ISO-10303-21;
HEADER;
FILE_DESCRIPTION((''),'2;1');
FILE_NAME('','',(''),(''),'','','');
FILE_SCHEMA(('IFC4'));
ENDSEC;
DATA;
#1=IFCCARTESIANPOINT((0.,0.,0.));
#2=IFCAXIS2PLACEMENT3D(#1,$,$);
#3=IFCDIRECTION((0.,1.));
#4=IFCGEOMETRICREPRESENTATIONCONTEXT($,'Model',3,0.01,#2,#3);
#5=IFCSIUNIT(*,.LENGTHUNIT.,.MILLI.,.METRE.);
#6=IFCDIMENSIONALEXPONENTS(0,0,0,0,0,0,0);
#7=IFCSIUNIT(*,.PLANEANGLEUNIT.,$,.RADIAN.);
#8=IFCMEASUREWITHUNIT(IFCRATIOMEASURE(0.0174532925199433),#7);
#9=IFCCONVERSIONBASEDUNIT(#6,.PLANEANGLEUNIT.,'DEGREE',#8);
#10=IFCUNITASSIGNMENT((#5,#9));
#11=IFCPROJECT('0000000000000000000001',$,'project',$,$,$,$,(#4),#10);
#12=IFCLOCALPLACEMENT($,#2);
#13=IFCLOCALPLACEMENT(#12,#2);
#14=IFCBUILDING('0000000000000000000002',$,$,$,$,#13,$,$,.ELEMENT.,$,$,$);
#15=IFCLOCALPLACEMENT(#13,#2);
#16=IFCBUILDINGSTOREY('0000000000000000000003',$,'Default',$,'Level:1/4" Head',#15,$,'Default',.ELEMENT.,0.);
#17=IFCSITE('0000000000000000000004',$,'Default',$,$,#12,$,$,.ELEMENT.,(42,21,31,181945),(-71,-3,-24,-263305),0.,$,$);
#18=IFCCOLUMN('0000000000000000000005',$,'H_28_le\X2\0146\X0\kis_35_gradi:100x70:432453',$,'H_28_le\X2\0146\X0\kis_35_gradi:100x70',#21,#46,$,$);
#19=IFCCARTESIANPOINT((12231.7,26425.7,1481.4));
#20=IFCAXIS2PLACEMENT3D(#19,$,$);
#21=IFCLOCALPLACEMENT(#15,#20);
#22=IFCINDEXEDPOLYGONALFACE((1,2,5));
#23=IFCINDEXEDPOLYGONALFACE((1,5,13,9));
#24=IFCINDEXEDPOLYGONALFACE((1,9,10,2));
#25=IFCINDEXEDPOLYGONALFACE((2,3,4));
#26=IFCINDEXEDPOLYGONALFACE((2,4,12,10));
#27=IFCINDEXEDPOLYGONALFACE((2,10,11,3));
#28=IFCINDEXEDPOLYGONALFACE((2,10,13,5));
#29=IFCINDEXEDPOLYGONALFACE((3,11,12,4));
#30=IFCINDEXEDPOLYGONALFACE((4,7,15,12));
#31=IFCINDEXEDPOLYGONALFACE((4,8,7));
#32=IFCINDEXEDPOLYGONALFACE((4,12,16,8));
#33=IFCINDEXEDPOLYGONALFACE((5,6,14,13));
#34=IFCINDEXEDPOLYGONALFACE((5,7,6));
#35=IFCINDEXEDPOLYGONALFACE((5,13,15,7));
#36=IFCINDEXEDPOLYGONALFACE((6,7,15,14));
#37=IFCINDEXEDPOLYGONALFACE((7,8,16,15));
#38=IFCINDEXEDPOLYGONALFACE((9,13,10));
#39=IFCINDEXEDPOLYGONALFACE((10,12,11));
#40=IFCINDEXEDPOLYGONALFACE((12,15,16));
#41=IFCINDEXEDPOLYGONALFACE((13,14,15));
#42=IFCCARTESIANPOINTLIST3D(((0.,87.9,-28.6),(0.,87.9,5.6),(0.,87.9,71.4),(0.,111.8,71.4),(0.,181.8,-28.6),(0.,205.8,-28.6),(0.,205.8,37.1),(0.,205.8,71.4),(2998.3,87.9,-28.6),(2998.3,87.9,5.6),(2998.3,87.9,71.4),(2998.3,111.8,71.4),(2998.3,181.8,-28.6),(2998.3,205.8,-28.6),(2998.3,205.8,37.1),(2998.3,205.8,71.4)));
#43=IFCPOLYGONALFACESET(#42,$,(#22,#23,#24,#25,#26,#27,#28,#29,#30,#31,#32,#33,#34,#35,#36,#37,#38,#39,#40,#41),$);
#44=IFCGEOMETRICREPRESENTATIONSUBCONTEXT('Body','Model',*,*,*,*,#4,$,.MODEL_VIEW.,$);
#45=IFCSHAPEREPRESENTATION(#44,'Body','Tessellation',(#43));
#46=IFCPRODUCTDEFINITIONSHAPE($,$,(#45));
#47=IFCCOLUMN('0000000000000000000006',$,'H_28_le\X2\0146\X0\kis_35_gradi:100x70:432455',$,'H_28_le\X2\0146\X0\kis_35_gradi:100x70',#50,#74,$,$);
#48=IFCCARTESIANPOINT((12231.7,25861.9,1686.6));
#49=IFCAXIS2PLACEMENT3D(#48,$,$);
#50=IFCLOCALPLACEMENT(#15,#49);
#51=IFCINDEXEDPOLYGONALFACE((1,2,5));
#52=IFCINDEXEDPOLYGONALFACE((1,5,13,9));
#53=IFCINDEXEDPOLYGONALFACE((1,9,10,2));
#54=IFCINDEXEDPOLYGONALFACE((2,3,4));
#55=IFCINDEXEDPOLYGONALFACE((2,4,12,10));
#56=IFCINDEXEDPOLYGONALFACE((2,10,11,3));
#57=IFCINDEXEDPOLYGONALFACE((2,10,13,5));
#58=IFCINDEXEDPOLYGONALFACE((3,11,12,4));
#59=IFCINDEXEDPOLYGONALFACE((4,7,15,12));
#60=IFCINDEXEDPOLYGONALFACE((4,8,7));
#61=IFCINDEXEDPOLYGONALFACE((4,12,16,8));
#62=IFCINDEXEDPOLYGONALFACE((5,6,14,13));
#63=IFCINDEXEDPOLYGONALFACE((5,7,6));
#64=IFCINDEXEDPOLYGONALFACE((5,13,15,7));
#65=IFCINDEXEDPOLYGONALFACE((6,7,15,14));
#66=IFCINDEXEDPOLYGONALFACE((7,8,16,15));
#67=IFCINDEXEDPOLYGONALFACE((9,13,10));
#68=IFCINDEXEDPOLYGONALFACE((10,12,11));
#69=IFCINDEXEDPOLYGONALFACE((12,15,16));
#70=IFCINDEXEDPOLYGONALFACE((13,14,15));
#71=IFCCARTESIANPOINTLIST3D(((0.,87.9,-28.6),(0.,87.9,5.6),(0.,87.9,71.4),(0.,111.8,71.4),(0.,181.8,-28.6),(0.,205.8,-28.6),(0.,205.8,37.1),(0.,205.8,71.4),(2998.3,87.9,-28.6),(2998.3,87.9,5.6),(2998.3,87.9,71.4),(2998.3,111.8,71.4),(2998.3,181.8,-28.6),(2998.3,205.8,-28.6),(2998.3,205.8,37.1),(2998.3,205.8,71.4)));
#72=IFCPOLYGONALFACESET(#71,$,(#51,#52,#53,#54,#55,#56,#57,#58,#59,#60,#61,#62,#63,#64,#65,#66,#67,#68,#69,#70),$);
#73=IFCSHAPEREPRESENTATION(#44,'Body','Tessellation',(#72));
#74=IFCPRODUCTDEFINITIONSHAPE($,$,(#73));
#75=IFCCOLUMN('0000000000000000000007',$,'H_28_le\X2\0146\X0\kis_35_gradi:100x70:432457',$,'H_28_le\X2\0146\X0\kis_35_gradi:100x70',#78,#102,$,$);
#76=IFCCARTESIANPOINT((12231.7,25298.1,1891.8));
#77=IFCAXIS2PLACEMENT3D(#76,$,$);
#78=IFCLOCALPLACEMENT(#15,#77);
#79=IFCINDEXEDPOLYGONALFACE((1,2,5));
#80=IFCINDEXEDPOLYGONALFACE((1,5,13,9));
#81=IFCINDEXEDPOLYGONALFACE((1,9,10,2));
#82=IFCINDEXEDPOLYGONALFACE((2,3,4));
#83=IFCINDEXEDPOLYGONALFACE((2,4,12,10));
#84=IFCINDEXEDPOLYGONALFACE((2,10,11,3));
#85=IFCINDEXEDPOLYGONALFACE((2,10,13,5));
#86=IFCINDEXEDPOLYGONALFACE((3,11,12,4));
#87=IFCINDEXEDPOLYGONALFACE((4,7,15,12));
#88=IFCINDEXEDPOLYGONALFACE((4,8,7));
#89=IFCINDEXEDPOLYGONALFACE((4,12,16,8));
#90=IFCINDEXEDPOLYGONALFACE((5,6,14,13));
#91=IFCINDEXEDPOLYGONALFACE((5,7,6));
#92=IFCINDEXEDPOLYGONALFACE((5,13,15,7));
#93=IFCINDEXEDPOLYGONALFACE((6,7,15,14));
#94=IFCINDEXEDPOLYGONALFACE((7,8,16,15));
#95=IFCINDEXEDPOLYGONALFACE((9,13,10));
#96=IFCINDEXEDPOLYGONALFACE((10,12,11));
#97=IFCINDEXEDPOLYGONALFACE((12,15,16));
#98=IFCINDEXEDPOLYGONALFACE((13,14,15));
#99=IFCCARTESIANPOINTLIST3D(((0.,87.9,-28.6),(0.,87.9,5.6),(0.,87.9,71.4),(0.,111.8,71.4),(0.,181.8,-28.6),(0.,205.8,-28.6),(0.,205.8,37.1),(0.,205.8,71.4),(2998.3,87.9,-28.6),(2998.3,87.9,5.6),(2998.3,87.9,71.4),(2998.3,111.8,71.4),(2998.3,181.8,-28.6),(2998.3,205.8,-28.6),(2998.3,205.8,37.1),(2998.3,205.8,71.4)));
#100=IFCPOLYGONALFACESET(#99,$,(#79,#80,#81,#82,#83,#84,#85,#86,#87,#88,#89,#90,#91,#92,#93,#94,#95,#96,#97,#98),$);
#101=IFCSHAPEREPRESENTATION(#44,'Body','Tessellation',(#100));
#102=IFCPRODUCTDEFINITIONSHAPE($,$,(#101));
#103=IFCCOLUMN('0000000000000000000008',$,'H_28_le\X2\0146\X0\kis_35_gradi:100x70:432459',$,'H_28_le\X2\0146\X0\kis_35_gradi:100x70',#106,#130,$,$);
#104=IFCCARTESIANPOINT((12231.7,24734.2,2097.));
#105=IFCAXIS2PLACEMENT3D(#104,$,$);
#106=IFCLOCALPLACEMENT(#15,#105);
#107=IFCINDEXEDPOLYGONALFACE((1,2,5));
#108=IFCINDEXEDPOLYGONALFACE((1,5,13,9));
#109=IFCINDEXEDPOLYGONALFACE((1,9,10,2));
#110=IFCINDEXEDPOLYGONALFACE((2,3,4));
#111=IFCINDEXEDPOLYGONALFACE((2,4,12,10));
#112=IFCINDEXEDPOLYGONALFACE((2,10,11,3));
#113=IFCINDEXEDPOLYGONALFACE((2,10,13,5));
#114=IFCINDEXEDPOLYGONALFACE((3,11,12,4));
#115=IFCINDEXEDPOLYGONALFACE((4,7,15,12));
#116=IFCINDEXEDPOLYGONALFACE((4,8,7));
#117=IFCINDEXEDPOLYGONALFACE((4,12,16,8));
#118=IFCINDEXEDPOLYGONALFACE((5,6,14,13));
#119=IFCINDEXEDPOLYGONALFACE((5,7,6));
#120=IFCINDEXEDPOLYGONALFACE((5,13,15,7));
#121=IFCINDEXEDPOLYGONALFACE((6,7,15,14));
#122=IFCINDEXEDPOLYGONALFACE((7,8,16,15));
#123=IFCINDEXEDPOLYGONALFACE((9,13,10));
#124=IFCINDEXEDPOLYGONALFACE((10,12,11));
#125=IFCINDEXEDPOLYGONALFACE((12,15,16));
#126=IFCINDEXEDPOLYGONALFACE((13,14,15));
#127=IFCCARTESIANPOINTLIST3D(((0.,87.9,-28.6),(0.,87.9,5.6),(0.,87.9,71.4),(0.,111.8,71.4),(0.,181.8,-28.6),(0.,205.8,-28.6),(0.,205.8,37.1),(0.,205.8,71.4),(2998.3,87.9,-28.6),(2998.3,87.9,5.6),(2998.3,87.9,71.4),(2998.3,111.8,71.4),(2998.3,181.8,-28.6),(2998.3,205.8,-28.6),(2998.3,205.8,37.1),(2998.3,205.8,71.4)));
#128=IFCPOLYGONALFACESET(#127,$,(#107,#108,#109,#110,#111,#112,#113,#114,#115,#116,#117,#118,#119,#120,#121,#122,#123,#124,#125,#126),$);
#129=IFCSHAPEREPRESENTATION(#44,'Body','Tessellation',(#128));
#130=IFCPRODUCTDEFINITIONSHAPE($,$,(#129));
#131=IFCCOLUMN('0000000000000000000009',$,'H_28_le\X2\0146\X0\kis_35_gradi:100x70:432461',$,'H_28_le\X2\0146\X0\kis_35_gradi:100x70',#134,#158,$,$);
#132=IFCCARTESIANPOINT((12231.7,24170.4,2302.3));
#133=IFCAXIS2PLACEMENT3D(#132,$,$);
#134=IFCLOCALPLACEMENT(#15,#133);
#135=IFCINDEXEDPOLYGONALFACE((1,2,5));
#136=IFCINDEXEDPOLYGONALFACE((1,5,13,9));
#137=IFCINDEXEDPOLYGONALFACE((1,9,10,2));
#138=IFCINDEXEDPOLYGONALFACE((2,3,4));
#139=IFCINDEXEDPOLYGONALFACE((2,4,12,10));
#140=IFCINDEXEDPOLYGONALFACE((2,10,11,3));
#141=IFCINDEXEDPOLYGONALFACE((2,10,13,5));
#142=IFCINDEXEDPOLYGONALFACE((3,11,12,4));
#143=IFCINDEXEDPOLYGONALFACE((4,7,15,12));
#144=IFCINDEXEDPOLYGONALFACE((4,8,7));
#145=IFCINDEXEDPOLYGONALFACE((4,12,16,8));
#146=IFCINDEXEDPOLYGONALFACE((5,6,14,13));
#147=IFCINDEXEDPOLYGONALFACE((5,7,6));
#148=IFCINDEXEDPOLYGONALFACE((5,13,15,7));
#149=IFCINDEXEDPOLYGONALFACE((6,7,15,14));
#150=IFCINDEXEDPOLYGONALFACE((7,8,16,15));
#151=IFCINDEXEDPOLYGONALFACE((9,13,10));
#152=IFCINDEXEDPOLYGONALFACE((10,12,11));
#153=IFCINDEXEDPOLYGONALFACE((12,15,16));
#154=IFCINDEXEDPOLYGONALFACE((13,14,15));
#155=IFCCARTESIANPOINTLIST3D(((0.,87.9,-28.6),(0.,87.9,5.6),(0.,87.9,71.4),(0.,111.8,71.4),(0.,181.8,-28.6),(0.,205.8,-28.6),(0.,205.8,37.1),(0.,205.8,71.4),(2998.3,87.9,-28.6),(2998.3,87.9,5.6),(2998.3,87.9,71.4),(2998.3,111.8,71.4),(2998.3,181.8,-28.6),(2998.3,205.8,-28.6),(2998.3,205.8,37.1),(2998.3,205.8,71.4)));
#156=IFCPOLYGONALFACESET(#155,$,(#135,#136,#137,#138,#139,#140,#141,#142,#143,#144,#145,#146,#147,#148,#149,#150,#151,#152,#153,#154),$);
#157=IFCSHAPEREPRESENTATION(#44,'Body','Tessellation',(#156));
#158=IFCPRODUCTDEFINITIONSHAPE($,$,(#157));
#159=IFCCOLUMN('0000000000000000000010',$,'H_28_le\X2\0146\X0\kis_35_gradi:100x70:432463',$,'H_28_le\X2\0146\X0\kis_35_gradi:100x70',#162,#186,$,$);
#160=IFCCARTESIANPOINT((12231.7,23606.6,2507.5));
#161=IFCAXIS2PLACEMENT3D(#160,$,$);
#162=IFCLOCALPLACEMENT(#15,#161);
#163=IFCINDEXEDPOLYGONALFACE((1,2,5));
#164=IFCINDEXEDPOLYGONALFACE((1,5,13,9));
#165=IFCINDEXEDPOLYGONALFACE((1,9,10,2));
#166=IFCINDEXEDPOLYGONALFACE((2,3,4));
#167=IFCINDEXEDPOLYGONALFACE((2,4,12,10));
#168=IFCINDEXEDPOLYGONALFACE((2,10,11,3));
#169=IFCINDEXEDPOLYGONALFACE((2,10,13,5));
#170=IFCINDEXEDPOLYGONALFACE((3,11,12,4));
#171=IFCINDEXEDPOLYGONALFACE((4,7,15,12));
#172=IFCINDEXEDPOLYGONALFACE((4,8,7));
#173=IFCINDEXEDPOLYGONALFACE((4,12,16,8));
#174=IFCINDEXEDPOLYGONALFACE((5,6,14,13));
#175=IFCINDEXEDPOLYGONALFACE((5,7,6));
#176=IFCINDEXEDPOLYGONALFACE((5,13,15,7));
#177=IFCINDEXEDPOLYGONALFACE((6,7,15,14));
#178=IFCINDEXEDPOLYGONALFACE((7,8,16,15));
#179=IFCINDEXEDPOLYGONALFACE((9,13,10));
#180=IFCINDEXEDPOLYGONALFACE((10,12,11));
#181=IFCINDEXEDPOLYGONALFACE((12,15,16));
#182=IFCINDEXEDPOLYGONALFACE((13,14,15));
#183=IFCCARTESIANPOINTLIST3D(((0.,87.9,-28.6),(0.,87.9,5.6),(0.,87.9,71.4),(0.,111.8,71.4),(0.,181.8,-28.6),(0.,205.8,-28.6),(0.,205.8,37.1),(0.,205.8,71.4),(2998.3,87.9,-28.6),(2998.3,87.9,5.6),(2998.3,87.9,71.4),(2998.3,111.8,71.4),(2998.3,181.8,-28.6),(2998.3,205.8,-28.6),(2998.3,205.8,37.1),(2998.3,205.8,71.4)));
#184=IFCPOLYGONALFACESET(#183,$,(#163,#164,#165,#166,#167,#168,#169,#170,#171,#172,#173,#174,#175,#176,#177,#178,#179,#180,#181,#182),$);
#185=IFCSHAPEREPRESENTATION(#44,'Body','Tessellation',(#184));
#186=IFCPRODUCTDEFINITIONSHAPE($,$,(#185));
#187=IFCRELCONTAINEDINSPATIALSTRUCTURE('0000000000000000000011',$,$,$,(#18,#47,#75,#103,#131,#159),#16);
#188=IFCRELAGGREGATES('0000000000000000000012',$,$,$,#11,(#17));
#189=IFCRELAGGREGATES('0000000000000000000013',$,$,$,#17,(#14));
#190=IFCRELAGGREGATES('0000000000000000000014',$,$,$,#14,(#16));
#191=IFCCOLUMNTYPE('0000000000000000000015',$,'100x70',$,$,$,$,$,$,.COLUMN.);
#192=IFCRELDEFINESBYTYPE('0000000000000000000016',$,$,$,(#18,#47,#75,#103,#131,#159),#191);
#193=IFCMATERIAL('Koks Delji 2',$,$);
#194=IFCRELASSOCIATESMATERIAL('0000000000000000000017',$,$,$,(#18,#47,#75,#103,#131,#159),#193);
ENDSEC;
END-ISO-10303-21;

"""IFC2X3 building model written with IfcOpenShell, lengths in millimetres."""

from ifc_helpers import new_model, entity, si_unit, converted_unit, direction, frame, frame_2d, origin, place, context, subcontext, project, spatial, rectangle, extrude, boolean, source, transform, mapped, material, type_object, type_shapes, element, save


model = new_model("IFC2X3")

# Units and contexts
model_context = context("Model", 3, precision=0.01, world=origin(), true_north=direction((0.0, 1.0)))
body_context = subcontext(model_context, "Body", "Model", "MODEL_VIEW")
ifc_project = project(units=[si_unit("LENGTHUNIT", "METRE", prefix="MILLI"), converted_unit("PLANEANGLEUNIT", "DEGREE", entity("IfcRatioMeasure", 0.0174532925199433), si_unit("PLANEANGLEUNIT", "RADIAN"), dimensions=[0, 0, 0, 0, 0, 0, 0])], contexts=[model_context])

# Site, building, storey
site_placement = place(None, origin())
site = spatial("IfcSite", under=ifc_project, at=site_placement, Name="Default", CompositionType="ELEMENT", RefLatitude=(42, 21, 31, 181945), RefLongitude=(-71, -3, -24, -263305), RefElevation=0.0)
building_placement = place(site_placement, origin())
building = spatial("IfcBuilding", under=site, at=building_placement, CompositionType="ELEMENT")
storey_placement = place(building_placement, origin())
storey = spatial("IfcBuildingStorey", under=building, at=storey_placement, Name="Default", ObjectType="Level:1/4\" Head", LongName="Default", CompositionType="ELEMENT", Elevation=0.0)

# Columns
ifc_material_1 = material(Name="Koks Delji 2")
column_type = type_object("IfcColumnType", Name="100x70", PredefinedType="COLUMN")
shared_shape_1 = source(origin(), body_context, "Body", "CSG", [
    boolean("DIFFERENCE", extrude(rectangle(XDim=2998.3, YDim=117.9, at=frame_2d((0.0, 0.0), x_axis=(1.0, 0.0))), frame((1499.1, 146.8, -28.6)), (0.0, 0.0, 1.0), 100.0), extrude(rectangle(XDim=70.0, YDim=100.0, at=frame_2d((0.0, 0.0), x_axis=(0.0, 1.0))), frame((2998.3, 146.8, 21.4), z_axis=(1.0, 0.0, 0.0), x_axis=(0.0, 0.939693, -0.34202)), (0.0, 0.0, -1.0), 2998.3)),
])
type_shapes(column_type, [shared_shape_1])
for number, where, name in (
    (1, (12231.7, 26425.7, 1481.4), "H_28_leņkis_35_gradi:100x70:432453"),
    (2, (12231.7, 25861.9, 1686.6), "H_28_leņkis_35_gradi:100x70:432455"),
    (3, (12231.7, 25298.1, 1891.8), "H_28_leņkis_35_gradi:100x70:432457"),
    (4, (12231.7, 24734.2, 2097.0), "H_28_leņkis_35_gradi:100x70:432459"),
    (5, (12231.7, 24170.4, 2302.3), "H_28_leņkis_35_gradi:100x70:432461"),
    (6, (12231.7, 23606.6, 2507.5), "H_28_leņkis_35_gradi:100x70:432463"),
):
    element("IfcColumn", number, at=place(storey_placement, frame(where)), inside=storey, type_object=column_type, material=ifc_material_1, Name=name, ObjectType="H_28_leņkis_35_gradi:100x70", context=body_context, shape_type="MappedRepresentation", body=[
        mapped(shared_shape_1, transform((0.0, 0.0, 0.0), scale=1.0)),
    ])

save(model, "model.ifc")
